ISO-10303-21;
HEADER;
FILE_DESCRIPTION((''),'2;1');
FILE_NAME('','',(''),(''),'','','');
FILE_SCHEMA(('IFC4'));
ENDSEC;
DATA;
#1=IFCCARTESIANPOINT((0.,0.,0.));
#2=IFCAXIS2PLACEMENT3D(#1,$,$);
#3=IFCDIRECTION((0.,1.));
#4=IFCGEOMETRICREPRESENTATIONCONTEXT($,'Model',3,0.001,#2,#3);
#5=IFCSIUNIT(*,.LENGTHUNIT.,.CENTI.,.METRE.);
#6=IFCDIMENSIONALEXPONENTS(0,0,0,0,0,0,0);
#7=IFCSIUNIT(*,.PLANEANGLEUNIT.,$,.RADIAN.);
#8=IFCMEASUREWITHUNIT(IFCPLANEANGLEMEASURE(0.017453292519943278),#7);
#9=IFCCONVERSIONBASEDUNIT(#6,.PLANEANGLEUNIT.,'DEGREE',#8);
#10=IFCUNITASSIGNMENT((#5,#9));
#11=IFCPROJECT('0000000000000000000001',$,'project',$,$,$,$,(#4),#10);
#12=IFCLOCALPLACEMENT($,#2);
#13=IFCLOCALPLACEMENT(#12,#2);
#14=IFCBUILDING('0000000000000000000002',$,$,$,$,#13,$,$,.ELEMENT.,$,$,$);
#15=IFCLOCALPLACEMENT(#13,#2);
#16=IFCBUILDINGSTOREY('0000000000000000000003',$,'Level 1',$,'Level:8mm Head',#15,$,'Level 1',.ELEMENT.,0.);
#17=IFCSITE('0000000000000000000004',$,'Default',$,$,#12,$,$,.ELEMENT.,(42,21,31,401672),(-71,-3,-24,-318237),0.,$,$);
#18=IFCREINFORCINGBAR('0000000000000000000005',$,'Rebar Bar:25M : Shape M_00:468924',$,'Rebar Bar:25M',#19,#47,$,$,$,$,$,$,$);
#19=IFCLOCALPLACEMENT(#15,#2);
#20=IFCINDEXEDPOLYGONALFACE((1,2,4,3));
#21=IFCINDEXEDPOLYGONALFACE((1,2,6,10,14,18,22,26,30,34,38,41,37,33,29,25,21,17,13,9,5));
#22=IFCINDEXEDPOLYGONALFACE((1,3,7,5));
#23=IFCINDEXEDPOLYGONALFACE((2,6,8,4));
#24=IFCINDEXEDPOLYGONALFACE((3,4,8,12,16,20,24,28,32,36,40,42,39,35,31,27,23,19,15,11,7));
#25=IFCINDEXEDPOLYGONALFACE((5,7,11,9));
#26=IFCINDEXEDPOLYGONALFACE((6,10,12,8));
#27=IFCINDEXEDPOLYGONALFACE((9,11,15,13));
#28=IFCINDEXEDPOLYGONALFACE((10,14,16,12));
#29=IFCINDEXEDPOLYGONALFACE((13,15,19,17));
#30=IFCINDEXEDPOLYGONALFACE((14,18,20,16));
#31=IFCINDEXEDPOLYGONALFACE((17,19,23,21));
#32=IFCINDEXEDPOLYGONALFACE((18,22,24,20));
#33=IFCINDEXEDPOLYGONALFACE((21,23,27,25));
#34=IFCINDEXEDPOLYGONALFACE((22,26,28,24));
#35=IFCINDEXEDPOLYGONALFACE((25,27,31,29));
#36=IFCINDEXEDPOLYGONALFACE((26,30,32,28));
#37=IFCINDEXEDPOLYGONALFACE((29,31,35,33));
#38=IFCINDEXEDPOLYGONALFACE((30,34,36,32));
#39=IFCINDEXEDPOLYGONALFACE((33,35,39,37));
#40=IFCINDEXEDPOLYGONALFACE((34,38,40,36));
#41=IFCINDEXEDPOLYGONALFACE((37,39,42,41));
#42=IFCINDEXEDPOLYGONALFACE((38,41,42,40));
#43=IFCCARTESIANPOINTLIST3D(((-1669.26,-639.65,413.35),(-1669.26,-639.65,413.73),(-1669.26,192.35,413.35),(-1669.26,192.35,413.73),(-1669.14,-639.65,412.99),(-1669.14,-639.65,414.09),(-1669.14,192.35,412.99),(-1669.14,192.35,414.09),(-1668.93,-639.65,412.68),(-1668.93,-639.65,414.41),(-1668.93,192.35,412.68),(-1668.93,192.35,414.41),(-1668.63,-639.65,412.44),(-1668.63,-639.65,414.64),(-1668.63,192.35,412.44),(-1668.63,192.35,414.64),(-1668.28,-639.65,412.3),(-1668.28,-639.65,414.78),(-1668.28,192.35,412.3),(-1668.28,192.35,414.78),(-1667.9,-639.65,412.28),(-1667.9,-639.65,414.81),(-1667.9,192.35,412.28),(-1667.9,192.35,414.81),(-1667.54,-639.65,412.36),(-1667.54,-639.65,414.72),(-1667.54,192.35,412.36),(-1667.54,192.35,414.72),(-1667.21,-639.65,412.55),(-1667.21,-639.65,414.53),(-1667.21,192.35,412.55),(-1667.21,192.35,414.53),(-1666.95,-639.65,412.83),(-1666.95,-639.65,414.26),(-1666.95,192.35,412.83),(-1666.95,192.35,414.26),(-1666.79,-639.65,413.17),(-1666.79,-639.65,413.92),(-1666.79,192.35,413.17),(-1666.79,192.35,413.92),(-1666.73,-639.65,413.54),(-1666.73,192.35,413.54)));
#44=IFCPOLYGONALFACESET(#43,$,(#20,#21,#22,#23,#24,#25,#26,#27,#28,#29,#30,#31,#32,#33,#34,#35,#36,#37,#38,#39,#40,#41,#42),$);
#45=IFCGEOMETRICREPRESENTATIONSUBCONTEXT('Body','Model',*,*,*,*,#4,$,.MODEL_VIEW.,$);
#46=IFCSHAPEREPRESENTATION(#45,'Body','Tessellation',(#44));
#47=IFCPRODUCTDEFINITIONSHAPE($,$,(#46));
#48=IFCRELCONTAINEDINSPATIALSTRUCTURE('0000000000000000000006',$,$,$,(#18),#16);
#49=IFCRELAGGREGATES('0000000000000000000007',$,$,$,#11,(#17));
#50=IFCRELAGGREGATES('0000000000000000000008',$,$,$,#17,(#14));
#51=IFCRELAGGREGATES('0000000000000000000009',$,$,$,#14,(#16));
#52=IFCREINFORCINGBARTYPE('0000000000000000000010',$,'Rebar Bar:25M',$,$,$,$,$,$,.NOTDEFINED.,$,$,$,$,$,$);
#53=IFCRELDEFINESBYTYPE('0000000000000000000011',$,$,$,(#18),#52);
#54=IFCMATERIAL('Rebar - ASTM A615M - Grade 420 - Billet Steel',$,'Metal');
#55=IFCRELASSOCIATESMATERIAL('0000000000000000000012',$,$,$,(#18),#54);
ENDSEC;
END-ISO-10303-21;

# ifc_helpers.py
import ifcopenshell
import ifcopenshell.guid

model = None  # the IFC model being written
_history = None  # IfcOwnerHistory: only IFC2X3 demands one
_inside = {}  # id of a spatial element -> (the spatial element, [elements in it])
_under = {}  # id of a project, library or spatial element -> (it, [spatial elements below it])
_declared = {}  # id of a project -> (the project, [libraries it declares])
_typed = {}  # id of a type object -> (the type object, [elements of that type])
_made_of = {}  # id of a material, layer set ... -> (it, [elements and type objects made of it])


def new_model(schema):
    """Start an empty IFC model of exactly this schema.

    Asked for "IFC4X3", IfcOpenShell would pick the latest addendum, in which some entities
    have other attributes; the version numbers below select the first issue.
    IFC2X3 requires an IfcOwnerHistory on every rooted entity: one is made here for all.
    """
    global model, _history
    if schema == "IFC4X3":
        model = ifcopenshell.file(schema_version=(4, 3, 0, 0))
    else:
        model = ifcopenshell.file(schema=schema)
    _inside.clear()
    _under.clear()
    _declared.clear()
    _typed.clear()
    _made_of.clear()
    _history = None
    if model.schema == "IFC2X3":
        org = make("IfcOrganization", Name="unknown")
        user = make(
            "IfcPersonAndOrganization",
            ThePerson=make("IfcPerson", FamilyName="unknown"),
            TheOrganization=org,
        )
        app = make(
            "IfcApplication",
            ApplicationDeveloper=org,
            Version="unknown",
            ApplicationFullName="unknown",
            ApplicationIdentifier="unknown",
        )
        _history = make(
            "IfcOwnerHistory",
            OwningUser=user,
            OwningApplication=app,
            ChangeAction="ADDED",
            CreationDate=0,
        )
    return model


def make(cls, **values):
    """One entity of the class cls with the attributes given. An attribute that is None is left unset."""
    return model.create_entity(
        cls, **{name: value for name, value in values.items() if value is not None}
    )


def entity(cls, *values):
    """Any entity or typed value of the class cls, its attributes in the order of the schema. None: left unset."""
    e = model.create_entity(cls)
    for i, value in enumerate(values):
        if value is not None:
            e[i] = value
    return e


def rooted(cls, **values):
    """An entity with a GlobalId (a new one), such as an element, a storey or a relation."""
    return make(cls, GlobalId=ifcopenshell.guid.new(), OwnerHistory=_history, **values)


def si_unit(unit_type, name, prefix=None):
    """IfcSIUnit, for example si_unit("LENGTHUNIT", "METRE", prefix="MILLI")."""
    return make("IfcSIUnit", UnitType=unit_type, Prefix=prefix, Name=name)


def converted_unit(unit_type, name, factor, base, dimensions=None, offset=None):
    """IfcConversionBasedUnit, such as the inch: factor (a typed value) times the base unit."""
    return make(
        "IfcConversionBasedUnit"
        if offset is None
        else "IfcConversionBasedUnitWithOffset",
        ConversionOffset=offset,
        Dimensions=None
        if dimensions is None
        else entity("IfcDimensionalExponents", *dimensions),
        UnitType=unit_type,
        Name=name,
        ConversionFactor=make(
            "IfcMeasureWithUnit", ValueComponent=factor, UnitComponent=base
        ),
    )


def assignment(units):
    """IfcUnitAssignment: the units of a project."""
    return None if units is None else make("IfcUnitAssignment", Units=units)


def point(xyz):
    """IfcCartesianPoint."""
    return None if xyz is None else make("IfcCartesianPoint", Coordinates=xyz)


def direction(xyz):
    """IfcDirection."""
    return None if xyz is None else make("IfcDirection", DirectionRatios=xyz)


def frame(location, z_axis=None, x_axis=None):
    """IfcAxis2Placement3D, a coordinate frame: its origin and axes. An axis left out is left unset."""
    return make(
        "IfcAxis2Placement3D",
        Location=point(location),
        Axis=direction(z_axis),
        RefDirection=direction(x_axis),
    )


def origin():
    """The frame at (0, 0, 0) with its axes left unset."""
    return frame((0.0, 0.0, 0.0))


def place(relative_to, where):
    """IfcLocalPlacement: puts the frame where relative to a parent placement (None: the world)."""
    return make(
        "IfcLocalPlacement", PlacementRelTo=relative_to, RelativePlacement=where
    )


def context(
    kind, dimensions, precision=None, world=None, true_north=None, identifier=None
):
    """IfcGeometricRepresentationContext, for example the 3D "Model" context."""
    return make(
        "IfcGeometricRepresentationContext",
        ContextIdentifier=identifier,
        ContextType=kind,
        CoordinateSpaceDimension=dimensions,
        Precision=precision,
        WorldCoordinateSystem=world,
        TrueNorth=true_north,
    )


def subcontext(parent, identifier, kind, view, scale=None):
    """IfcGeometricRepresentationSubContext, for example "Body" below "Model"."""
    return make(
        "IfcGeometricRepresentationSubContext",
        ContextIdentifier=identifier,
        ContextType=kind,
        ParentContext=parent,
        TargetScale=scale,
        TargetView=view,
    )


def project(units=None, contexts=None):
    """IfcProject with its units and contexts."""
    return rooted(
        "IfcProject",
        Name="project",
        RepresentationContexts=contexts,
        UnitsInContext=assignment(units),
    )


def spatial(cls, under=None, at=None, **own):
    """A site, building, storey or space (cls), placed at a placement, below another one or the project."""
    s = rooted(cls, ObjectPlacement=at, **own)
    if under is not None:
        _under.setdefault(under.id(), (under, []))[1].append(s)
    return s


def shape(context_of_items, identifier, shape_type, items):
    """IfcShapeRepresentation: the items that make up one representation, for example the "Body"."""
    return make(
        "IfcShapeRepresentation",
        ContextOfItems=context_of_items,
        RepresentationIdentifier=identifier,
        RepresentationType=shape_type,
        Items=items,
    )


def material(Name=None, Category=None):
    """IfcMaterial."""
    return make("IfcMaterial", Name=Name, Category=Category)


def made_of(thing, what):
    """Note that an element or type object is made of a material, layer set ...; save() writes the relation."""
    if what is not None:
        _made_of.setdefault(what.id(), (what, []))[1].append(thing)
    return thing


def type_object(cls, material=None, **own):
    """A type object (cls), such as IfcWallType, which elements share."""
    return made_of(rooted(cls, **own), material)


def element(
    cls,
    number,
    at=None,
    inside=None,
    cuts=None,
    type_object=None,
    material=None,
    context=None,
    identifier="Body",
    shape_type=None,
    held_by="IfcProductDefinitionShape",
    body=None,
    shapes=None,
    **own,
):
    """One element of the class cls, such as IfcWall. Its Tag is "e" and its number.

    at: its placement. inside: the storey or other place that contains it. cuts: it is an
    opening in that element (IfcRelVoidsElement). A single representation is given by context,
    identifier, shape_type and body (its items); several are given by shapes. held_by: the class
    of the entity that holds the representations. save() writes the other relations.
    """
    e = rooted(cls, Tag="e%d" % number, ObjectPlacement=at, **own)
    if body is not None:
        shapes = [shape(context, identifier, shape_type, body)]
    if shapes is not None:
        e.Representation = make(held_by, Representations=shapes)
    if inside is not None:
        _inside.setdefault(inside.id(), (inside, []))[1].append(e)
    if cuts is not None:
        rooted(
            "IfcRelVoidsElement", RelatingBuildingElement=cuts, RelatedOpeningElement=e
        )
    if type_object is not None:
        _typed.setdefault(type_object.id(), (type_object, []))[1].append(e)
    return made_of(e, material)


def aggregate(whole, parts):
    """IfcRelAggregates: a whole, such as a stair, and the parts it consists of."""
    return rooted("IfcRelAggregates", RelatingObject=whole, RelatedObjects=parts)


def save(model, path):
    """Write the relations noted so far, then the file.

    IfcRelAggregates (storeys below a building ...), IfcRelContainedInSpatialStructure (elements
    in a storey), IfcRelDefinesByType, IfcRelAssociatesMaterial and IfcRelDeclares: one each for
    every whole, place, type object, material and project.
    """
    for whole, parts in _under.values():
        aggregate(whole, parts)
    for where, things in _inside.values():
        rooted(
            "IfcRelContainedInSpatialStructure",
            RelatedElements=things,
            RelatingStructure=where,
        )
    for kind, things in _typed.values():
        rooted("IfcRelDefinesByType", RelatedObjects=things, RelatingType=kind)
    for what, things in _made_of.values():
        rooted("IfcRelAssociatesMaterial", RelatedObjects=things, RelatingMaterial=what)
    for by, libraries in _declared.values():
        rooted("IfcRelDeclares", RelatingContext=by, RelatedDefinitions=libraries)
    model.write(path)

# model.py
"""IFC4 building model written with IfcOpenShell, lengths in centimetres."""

from ifc_helpers import new_model, entity, si_unit, converted_unit, direction, origin, place, context, subcontext, project, spatial, material, type_object, element, save


model = new_model("IFC4")

# Units and contexts
model_context = context("Model", 3, precision=0.001, world=origin(), true_north=direction((0.0, 1.0)))
body_context = subcontext(model_context, "Body", "Model", "MODEL_VIEW")
ifc_project = project(units=[si_unit("LENGTHUNIT", "METRE", prefix="CENTI"), converted_unit("PLANEANGLEUNIT", "DEGREE", entity("IfcPlaneAngleMeasure", 0.017453292519943278), si_unit("PLANEANGLEUNIT", "RADIAN"), dimensions=[0, 0, 0, 0, 0, 0, 0])], contexts=[model_context])

# Site, building, storey
site_placement = place(None, origin())
site = spatial("IfcSite", under=ifc_project, at=site_placement, Name="Default", CompositionType="ELEMENT", RefLatitude=(42, 21, 31, 401672), RefLongitude=(-71, -3, -24, -318237), RefElevation=0.0)
building_placement = place(site_placement, origin())
building = spatial("IfcBuilding", under=site, at=building_placement, CompositionType="ELEMENT")
storey_placement = place(building_placement, origin())
storey = spatial("IfcBuildingStorey", under=building, at=storey_placement, Name="Level 1", ObjectType="Level:8mm Head", LongName="Level 1", CompositionType="ELEMENT", Elevation=0.0)

# Reinforcing bar
ifc_material_1 = material(Name="Rebar - ASTM A615M - Grade 420 - Billet Steel", Category="Metal")
reinforcing_bar_type_1 = type_object("IfcReinforcingBarType", Name="Rebar Bar:25M", PredefinedType="NOTDEFINED")
reinforcing_bar_1_placement = place(storey_placement, origin())
element("IfcReinforcingBar", 1, at=reinforcing_bar_1_placement, inside=storey, type_object=reinforcing_bar_type_1, material=ifc_material_1, Name="Rebar Bar:25M : Shape M_00:468924", ObjectType="Rebar Bar:25M", context=body_context, shape_type="AdvancedSweptSolid", body=[
    entity("IfcSweptDiskSolid", entity("IfcIndexedPolyCurve", entity("IfcCartesianPointList3D", [[-1668.0, -639.65, 413.54], [-1668.0, 192.35, 413.54]]), None, False), 1.27, None, 0.0, 1.0),
])

save(model, "model.ifc")
